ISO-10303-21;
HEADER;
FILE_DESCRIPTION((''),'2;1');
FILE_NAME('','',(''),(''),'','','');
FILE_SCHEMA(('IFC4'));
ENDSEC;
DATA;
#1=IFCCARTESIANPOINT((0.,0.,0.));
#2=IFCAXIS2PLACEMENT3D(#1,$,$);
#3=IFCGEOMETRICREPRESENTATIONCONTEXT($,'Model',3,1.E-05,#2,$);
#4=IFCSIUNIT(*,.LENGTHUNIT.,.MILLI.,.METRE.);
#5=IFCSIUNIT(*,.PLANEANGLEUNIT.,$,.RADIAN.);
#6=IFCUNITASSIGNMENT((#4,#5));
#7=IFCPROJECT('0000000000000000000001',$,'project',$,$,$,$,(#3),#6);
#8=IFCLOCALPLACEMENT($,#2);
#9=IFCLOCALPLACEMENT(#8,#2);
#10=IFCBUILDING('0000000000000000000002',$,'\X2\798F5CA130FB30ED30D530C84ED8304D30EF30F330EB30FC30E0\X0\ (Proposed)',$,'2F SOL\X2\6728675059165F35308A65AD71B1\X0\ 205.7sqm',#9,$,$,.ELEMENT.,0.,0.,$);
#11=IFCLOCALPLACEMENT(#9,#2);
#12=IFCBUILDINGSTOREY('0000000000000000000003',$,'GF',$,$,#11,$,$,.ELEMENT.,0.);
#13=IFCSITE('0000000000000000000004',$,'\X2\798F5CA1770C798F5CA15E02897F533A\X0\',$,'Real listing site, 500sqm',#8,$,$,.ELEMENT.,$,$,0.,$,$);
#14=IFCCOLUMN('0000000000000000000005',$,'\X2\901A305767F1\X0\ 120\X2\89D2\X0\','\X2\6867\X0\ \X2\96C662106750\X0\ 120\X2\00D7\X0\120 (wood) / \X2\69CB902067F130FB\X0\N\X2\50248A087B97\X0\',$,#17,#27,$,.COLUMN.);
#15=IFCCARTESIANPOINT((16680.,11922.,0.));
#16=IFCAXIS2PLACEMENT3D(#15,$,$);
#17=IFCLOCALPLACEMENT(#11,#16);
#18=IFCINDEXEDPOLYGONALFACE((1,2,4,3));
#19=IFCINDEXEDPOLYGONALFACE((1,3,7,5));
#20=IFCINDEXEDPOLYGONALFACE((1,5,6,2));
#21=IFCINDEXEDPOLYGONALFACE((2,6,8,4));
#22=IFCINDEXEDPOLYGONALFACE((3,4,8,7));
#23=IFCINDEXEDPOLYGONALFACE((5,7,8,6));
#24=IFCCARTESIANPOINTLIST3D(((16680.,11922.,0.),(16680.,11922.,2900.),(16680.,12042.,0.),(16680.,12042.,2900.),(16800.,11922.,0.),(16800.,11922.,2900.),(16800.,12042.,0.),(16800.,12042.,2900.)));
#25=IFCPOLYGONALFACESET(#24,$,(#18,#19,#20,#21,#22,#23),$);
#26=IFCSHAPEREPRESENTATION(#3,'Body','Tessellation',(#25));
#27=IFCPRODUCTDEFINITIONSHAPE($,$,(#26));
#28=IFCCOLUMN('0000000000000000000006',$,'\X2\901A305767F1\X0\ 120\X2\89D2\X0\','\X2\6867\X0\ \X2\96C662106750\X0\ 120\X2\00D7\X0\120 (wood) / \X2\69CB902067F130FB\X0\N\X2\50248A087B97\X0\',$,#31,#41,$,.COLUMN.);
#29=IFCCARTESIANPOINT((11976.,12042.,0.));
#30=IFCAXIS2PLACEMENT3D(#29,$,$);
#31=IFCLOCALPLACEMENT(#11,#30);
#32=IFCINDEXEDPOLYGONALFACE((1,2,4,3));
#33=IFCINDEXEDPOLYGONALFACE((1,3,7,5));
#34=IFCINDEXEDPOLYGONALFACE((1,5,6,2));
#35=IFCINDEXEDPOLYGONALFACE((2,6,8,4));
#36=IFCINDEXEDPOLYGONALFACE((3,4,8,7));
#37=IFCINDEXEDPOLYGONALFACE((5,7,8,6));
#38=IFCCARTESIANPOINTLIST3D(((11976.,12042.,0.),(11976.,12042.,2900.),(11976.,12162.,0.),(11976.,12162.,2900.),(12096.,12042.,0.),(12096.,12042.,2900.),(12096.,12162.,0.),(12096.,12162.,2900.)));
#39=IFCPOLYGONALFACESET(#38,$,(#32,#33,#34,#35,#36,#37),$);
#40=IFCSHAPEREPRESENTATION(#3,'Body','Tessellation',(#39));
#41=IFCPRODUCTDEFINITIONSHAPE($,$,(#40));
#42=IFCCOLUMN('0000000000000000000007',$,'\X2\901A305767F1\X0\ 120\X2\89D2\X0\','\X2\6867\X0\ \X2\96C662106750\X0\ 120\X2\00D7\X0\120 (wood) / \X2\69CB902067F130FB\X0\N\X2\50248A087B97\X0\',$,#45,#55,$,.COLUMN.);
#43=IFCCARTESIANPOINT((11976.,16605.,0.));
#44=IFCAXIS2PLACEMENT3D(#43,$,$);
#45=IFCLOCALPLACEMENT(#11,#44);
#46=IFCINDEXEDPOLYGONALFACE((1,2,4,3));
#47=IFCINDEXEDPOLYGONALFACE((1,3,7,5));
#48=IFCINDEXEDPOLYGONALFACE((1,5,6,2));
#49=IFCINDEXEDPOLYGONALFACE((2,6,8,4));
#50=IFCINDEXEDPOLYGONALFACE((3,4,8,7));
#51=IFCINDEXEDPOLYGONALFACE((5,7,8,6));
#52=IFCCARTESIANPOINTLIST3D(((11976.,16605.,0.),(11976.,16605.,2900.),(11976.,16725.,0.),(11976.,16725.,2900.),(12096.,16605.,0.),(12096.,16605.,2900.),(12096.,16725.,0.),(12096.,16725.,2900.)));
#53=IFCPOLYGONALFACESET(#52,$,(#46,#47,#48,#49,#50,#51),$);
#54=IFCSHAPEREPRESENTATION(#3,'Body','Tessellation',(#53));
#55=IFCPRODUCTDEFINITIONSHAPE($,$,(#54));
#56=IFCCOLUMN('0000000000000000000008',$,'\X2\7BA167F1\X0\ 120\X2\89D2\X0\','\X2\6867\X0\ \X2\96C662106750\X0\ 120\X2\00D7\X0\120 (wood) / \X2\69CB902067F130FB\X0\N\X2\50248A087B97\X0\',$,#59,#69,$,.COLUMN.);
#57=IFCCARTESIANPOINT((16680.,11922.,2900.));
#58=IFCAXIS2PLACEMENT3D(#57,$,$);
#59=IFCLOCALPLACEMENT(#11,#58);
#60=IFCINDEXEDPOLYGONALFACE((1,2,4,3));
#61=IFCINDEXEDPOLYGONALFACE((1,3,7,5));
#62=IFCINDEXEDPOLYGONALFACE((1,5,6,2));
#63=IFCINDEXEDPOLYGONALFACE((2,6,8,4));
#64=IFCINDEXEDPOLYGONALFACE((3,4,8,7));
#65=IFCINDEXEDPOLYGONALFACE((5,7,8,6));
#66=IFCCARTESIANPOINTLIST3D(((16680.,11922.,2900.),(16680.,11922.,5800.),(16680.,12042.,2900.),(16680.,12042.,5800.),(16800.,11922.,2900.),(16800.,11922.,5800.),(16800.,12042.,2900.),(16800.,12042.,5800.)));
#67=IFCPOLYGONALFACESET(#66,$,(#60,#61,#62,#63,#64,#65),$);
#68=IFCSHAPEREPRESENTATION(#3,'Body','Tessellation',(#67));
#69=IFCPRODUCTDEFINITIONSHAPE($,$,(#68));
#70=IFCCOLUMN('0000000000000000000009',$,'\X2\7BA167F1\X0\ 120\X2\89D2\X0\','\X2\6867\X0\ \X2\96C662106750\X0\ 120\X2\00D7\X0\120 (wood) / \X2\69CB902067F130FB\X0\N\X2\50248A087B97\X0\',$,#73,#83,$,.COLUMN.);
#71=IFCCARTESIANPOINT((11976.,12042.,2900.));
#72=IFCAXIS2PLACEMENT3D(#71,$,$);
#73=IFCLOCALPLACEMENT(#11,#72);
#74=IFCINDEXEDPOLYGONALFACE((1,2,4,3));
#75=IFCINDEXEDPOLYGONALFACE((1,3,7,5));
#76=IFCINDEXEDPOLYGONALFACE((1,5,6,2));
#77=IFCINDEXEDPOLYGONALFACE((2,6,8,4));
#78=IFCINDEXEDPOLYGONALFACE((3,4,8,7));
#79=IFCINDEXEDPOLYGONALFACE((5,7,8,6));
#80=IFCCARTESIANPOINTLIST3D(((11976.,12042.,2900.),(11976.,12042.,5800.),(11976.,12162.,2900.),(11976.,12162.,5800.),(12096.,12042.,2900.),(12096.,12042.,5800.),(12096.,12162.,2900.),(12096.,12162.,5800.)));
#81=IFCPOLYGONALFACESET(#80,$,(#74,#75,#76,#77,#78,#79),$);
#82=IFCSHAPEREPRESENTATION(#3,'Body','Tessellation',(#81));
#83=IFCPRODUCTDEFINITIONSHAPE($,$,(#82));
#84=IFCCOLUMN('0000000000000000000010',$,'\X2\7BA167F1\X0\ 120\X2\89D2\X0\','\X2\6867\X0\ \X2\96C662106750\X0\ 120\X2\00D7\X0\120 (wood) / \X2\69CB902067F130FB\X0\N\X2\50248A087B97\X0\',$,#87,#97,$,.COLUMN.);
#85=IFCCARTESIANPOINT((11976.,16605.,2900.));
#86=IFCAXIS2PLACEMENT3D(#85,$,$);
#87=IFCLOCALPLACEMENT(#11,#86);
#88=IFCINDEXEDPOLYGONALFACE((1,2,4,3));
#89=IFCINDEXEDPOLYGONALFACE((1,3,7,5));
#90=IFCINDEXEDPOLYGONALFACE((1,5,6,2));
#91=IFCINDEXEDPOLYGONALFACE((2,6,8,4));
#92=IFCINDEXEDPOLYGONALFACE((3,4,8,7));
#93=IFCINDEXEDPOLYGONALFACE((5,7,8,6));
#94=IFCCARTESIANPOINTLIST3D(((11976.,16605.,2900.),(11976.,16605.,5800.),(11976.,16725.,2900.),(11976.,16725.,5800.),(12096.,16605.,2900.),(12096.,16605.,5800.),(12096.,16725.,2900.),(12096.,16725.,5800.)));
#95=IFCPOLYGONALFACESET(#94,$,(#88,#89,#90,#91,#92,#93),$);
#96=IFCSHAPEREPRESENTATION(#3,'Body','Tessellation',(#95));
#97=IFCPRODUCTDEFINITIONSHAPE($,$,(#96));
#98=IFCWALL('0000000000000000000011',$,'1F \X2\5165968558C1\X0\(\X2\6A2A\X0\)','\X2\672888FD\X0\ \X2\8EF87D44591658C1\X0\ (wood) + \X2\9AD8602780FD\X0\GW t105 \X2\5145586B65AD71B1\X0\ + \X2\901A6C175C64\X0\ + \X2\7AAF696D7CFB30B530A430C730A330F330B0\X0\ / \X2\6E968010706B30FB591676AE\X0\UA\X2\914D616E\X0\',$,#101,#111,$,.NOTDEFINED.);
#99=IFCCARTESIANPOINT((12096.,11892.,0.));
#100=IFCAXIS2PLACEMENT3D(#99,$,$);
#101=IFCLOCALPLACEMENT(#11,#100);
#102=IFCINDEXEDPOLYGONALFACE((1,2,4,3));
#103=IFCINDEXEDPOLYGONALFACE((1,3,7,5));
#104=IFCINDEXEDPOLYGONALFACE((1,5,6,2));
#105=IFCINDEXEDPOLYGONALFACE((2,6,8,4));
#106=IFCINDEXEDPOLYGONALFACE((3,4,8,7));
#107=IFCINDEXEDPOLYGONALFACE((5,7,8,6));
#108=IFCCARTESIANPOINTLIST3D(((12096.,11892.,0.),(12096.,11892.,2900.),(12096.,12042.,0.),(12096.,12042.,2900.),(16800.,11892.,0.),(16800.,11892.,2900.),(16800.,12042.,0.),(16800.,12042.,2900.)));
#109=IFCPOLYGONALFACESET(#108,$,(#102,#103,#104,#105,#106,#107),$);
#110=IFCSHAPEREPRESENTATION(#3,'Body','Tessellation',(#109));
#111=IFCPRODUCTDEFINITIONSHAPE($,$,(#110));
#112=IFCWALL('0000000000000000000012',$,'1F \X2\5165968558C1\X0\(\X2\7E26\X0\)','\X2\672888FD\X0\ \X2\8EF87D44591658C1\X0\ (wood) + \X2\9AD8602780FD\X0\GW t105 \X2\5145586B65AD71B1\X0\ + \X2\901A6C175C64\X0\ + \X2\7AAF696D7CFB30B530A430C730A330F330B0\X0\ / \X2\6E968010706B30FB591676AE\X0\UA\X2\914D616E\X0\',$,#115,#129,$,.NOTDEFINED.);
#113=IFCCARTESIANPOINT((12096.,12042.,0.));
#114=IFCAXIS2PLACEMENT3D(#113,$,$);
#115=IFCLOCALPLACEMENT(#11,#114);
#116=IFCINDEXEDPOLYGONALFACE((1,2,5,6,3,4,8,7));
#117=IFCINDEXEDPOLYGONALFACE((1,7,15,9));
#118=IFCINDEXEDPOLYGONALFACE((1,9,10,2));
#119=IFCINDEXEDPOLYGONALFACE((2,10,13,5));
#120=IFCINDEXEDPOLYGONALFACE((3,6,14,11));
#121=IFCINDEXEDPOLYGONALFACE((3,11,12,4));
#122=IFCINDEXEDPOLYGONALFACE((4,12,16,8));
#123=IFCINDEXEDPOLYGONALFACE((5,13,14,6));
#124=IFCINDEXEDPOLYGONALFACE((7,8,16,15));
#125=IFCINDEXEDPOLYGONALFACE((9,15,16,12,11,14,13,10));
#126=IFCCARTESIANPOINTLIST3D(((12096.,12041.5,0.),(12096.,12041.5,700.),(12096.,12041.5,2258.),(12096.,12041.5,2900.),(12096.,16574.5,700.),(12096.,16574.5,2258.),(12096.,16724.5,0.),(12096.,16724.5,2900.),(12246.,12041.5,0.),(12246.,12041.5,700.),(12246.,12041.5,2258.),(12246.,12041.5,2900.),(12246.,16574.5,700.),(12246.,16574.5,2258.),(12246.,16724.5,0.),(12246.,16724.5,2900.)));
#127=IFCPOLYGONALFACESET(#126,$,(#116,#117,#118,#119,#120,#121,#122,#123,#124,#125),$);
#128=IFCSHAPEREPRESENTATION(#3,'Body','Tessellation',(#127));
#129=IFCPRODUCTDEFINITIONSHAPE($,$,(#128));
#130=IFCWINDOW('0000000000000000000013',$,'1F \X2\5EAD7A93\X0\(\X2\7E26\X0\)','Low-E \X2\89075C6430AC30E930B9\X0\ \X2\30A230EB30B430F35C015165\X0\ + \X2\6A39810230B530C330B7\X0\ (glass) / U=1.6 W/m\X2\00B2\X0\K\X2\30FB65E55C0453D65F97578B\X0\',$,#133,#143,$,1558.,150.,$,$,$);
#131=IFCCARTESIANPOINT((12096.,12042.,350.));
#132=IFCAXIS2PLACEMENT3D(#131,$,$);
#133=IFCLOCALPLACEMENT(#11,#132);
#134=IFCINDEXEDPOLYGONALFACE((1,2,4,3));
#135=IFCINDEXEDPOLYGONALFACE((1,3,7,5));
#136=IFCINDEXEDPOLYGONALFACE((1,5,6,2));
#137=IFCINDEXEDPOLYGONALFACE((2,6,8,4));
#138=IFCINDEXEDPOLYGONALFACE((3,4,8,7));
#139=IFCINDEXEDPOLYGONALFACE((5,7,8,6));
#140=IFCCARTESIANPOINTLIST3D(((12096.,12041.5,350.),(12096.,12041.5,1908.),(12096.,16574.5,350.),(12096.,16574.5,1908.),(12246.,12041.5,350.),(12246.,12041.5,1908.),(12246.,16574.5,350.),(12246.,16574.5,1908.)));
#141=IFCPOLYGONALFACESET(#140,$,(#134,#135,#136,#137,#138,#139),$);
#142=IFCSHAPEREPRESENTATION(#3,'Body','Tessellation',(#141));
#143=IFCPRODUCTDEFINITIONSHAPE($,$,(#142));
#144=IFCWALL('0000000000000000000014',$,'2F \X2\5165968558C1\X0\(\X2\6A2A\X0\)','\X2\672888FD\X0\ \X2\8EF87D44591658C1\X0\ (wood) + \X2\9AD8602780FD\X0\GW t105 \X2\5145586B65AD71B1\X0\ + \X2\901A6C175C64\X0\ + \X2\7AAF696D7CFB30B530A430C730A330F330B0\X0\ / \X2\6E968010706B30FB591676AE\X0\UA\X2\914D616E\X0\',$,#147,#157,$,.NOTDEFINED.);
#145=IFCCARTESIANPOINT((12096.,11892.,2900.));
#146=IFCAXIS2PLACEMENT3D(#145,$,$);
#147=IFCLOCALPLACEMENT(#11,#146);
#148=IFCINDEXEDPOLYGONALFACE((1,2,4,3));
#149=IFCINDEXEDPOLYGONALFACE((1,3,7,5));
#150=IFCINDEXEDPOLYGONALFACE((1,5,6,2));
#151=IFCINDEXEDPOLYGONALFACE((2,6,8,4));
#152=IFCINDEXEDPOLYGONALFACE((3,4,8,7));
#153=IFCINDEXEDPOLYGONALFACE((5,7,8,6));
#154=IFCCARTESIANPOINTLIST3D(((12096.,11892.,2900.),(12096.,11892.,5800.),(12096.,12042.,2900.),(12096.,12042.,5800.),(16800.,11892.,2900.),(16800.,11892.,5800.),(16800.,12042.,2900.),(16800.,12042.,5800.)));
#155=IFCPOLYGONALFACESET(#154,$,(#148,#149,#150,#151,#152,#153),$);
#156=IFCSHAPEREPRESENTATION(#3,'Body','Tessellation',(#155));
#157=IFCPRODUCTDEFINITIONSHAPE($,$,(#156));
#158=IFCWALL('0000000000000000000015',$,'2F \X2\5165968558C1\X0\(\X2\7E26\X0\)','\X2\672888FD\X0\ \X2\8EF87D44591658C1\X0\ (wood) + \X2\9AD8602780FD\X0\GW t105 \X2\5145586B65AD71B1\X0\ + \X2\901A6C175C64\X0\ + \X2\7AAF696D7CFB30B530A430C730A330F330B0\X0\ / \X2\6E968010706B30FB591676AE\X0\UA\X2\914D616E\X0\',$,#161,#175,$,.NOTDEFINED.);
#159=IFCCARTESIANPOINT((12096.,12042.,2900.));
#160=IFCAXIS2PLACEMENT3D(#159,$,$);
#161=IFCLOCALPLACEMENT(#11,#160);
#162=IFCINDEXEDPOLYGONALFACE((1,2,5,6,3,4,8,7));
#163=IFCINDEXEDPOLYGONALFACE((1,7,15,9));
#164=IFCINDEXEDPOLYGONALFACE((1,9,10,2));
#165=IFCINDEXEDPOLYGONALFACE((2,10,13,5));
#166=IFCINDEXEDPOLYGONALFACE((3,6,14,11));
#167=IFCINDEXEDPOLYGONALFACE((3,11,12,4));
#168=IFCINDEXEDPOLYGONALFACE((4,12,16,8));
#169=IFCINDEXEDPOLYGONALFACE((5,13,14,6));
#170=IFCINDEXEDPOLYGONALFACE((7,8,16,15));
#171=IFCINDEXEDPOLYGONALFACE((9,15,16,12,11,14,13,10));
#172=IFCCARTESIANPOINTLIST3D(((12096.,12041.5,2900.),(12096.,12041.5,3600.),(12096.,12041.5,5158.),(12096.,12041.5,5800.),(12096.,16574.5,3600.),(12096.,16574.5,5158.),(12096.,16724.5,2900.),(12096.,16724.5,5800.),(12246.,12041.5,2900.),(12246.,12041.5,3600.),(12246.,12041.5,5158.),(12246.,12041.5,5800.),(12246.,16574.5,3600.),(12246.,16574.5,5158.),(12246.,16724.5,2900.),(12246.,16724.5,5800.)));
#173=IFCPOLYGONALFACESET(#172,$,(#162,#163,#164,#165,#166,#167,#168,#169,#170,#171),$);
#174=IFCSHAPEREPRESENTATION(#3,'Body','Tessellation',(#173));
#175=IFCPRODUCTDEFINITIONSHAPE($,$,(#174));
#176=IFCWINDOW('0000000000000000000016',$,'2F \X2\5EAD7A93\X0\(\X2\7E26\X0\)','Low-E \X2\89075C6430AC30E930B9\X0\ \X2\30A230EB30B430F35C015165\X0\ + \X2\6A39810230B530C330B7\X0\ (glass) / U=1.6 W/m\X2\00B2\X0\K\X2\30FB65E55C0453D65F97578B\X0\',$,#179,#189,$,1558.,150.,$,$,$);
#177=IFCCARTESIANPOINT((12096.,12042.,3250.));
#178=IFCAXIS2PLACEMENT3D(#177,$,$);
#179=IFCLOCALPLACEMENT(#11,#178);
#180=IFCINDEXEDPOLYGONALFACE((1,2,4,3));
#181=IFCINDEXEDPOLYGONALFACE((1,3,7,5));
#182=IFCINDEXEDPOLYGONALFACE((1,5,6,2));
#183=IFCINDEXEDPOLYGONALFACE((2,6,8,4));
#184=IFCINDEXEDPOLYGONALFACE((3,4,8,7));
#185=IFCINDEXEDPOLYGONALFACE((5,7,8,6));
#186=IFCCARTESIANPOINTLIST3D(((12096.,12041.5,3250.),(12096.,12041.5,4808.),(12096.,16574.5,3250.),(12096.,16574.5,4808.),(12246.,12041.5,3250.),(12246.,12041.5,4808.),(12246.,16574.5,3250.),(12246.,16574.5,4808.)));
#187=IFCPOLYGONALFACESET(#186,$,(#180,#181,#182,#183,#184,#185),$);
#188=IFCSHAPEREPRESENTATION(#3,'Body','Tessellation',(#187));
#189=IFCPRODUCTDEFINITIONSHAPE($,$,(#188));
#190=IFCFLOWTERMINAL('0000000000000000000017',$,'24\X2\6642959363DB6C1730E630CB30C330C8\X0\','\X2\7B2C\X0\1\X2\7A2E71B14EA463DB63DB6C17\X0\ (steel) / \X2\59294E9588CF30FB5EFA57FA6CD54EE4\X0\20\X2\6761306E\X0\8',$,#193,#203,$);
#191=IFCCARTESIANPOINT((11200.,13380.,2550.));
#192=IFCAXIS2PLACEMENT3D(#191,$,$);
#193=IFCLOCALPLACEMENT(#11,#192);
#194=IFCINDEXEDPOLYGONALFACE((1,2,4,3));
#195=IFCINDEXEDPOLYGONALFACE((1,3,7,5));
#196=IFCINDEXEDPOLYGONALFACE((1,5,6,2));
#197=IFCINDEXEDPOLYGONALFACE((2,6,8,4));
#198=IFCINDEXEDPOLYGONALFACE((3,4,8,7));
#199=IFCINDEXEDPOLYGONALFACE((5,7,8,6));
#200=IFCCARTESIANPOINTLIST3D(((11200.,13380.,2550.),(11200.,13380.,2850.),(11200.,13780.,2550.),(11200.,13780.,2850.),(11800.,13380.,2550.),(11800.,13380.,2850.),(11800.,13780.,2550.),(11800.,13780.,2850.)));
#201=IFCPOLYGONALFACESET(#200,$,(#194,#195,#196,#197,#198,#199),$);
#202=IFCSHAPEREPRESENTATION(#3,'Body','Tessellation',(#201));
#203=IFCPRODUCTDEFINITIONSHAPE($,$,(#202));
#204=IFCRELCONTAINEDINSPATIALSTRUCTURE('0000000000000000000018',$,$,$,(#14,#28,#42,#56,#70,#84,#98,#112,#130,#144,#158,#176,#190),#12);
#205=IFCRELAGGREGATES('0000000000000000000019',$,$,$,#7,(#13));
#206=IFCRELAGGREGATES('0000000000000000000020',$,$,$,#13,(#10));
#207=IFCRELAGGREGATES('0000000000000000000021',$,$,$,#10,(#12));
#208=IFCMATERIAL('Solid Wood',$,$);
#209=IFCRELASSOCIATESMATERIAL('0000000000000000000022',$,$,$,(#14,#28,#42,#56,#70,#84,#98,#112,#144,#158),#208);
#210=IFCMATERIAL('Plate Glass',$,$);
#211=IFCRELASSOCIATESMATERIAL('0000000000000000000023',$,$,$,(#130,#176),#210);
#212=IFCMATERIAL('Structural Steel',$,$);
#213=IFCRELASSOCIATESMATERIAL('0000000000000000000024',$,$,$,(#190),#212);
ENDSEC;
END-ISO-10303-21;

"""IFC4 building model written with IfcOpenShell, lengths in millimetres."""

from ifc_helpers import new_model, si_unit, frame, frame_2d, origin, place, context, project, spatial, rectangle, extrude, material, element, fill, save


model = new_model("IFC4")

# Units and contexts
model_context = context("Model", 3, precision=1e-05, world=origin())
ifc_project = project(units=[si_unit("LENGTHUNIT", "METRE", prefix="MILLI"), si_unit("PLANEANGLEUNIT", "RADIAN")], contexts=[model_context])

# Site, building, storey
site_placement = place(None, origin())
site = spatial("IfcSite", under=ifc_project, at=site_placement, Name="福岡県福岡市西区", ObjectType="Real listing site, 500sqm", CompositionType="ELEMENT", RefElevation=0.0)
building_placement = place(site_placement, origin())
building = spatial("IfcBuilding", under=site, at=building_placement, Name="福岡・ロフト付きワンルーム (Proposed)", ObjectType="2F SOL木材外張り断熱 205.7sqm", CompositionType="ELEMENT", ElevationOfRefHeight=0.0, ElevationOfTerrain=0.0)
storey_placement = place(building_placement, origin())
storey = spatial("IfcBuildingStorey", under=building, at=storey_placement, Name="GF", CompositionType="ELEMENT", Elevation=0.0)

# Columns
ifc_material_1 = material(Name="Solid Wood")
column_1_placement = place(storey_placement, frame((16680.0, 11922.0, 0.0)))
element("IfcColumn", 1, at=column_1_placement, inside=storey, material=ifc_material_1, Name="通し柱 120角", Description="桧 集成材 120×120 (wood) / 構造柱・N値計算", PredefinedType="COLUMN", context=model_context, shape_type="SweptSolid", body=[
    extrude(rectangle(XDim=120.0, YDim=120.0, at=frame_2d((60.0, 60.0))), frame((16680.0, 11922.0, 0.0)), (0.0, 0.0, 1.0), 2900.0),
])
column_2_placement = place(storey_placement, frame((11976.0, 12042.0, 0.0)))
element("IfcColumn", 2, at=column_2_placement, inside=storey, material=ifc_material_1, Name="通し柱 120角", Description="桧 集成材 120×120 (wood) / 構造柱・N値計算", PredefinedType="COLUMN", context=model_context, shape_type="SweptSolid", body=[
    extrude(rectangle(XDim=120.0, YDim=120.0, at=frame_2d((60.0, 60.0))), frame((11976.0, 12042.0, 0.0)), (0.0, 0.0, 1.0), 2900.0),
])
column_3_placement = place(storey_placement, frame((11976.0, 16605.0, 0.0)))
element("IfcColumn", 3, at=column_3_placement, inside=storey, material=ifc_material_1, Name="通し柱 120角", Description="桧 集成材 120×120 (wood) / 構造柱・N値計算", PredefinedType="COLUMN", context=model_context, shape_type="SweptSolid", body=[
    extrude(rectangle(XDim=120.0, YDim=120.0, at=frame_2d((60.0, 60.0))), frame((11976.0, 16605.0, 0.0)), (0.0, 0.0, 1.0), 2900.0),
])
column_4_placement = place(storey_placement, frame((16680.0, 11922.0, 2900.0)))
element("IfcColumn", 4, at=column_4_placement, inside=storey, material=ifc_material_1, Name="管柱 120角", Description="桧 集成材 120×120 (wood) / 構造柱・N値計算", PredefinedType="COLUMN", context=model_context, shape_type="SweptSolid", body=[
    extrude(rectangle(XDim=120.0, YDim=120.0, at=frame_2d((60.0, 60.0))), frame((16680.0, 11922.0, 2900.0)), (0.0, 0.0, 1.0), 2900.0),
])
column_5_placement = place(storey_placement, frame((11976.0, 12042.0, 2900.0)))
element("IfcColumn", 5, at=column_5_placement, inside=storey, material=ifc_material_1, Name="管柱 120角", Description="桧 集成材 120×120 (wood) / 構造柱・N値計算", PredefinedType="COLUMN", context=model_context, shape_type="SweptSolid", body=[
    extrude(rectangle(XDim=120.0, YDim=120.0, at=frame_2d((60.0, 60.0))), frame((11976.0, 12042.0, 2900.0)), (0.0, 0.0, 1.0), 2900.0),
])
column_6_placement = place(storey_placement, frame((11976.0, 16605.0, 2900.0)))
element("IfcColumn", 6, at=column_6_placement, inside=storey, material=ifc_material_1, Name="管柱 120角", Description="桧 集成材 120×120 (wood) / 構造柱・N値計算", PredefinedType="COLUMN", context=model_context, shape_type="SweptSolid", body=[
    extrude(rectangle(XDim=120.0, YDim=120.0, at=frame_2d((60.0, 60.0))), frame((11976.0, 16605.0, 2900.0)), (0.0, 0.0, 1.0), 2900.0),
])

# Wall
wall_1_placement = place(storey_placement, frame((12096.0, 11892.0, 0.0)))
element("IfcWall", 7, at=wall_1_placement, inside=storey, material=ifc_material_1, Name="1F 入隅壁(横)", Description="木製 軸組外壁 (wood) + 高性能GW t105 充填断熱 + 通気層 + 窯業系サイディング / 準耐火・外皮UA配慮", PredefinedType="NOTDEFINED", context=model_context, shape_type="SweptSolid", body=[
    extrude(rectangle(XDim=4704.0, YDim=150.0, at=frame_2d((2352.0, 75.0))), frame((12096.0, 11892.0, 0.0)), (0.0, 0.0, 1.0), 2900.0),
])

# Wall, opening, window
wall_2_placement = place(storey_placement, frame((12096.0, 12042.0, 0.0)))
wall_2 = element("IfcWall", 8, at=wall_2_placement, inside=storey, material=ifc_material_1, Name="1F 入隅壁(縦)", Description="木製 軸組外壁 (wood) + 高性能GW t105 充填断熱 + 通気層 + 窯業系サイディング / 準耐火・外皮UA配慮", PredefinedType="NOTDEFINED", context=model_context, shape_type="SweptSolid", body=[
    extrude(rectangle(XDim=150.0, YDim=4683.0, at=frame_2d((75.0, 2341.0))), frame((12096.0, 12042.0, 0.0)), (0.0, 0.0, 1.0), 2900.0),
])
opening_1_placement = place(storey_placement, frame((12096.0, 12042.0, 350.0)))
opening_1 = element("IfcOpeningElement", 9, at=opening_1_placement, cuts=wall_2, PredefinedType="NOTDEFINED", context=model_context, shape_type="SweptSolid", body=[
    extrude(rectangle(XDim=150.0, YDim=4533.0, at=frame_2d((75.0, 2266.0))), frame((12096.0, 12042.0, 350.0)), (0.0, 0.0, 1.0), 1558.0),
])
ifc_material_2 = material(Name="Plate Glass")
window_1_placement = place(storey_placement, frame((12096.0, 12042.0, 350.0)))
window_1 = element("IfcWindow", 10, at=window_1_placement, inside=storey, material=ifc_material_2, Name="1F 庭窓(縦)", Description="Low-E 複層ガラス アルゴン封入 + 樹脂サッシ (glass) / U=1.6 W/m²K・日射取得型", OverallHeight=1558.0, OverallWidth=150.0, context=model_context, shape_type="SweptSolid", body=[
    extrude(rectangle(XDim=150.0, YDim=4533.0, at=frame_2d((75.0, 2266.0))), frame((12096.0, 12042.0, 350.0)), (0.0, 0.0, 1.0), 1558.0),
])
fill(opening_1, window_1)

# Wall
wall_3_placement = place(storey_placement, frame((12096.0, 11892.0, 2900.0)))
element("IfcWall", 11, at=wall_3_placement, inside=storey, material=ifc_material_1, Name="2F 入隅壁(横)", Description="木製 軸組外壁 (wood) + 高性能GW t105 充填断熱 + 通気層 + 窯業系サイディング / 準耐火・外皮UA配慮", PredefinedType="NOTDEFINED", context=model_context, shape_type="SweptSolid", body=[
    extrude(rectangle(XDim=4704.0, YDim=150.0, at=frame_2d((2352.0, 75.0))), frame((12096.0, 11892.0, 2900.0)), (0.0, 0.0, 1.0), 2900.0),
])

# Wall, opening, window
wall_4_placement = place(storey_placement, frame((12096.0, 12042.0, 2900.0)))
wall_4 = element("IfcWall", 12, at=wall_4_placement, inside=storey, material=ifc_material_1, Name="2F 入隅壁(縦)", Description="木製 軸組外壁 (wood) + 高性能GW t105 充填断熱 + 通気層 + 窯業系サイディング / 準耐火・外皮UA配慮", PredefinedType="NOTDEFINED", context=model_context, shape_type="SweptSolid", body=[
    extrude(rectangle(XDim=150.0, YDim=4683.0, at=frame_2d((75.0, 2341.0))), frame((12096.0, 12042.0, 2900.0)), (0.0, 0.0, 1.0), 2900.0),
])
opening_2_placement = place(storey_placement, frame((12096.0, 12042.0, 3250.0)))
opening_2 = element("IfcOpeningElement", 13, at=opening_2_placement, cuts=wall_4, PredefinedType="NOTDEFINED", context=model_context, shape_type="SweptSolid", body=[
    extrude(rectangle(XDim=150.0, YDim=4533.0, at=frame_2d((75.0, 2266.0))), frame((12096.0, 12042.0, 3250.0)), (0.0, 0.0, 1.0), 1558.0),
])
window_2_placement = place(storey_placement, frame((12096.0, 12042.0, 3250.0)))
window_2 = element("IfcWindow", 14, at=window_2_placement, inside=storey, material=ifc_material_2, Name="2F 庭窓(縦)", Description="Low-E 複層ガラス アルゴン封入 + 樹脂サッシ (glass) / U=1.6 W/m²K・日射取得型", OverallHeight=1558.0, OverallWidth=150.0, context=model_context, shape_type="SweptSolid", body=[
    extrude(rectangle(XDim=150.0, YDim=4533.0, at=frame_2d((75.0, 2266.0))), frame((12096.0, 12042.0, 3250.0)), (0.0, 0.0, 1.0), 1558.0),
])
fill(opening_2, window_2)

# Flow terminal
ifc_material_3 = material(Name="Structural Steel")
flow_terminal_placement = place(storey_placement, frame((11200.0, 13380.0, 2550.0)))
element("IfcFlowTerminal", 15, at=flow_terminal_placement, inside=storey, material=ifc_material_3, Name="24時間換気ユニット", Description="第1種熱交換換気 (steel) / 天井裏・建基法令20条の8", context=model_context, shape_type="SweptSolid", body=[
    extrude(rectangle(XDim=600.0, YDim=400.0, at=frame_2d((300.0, 200.0))), frame((11200.0, 13380.0, 2550.0)), (0.0, 0.0, 1.0), 300.0),
])

save(model, "model.ifc")
